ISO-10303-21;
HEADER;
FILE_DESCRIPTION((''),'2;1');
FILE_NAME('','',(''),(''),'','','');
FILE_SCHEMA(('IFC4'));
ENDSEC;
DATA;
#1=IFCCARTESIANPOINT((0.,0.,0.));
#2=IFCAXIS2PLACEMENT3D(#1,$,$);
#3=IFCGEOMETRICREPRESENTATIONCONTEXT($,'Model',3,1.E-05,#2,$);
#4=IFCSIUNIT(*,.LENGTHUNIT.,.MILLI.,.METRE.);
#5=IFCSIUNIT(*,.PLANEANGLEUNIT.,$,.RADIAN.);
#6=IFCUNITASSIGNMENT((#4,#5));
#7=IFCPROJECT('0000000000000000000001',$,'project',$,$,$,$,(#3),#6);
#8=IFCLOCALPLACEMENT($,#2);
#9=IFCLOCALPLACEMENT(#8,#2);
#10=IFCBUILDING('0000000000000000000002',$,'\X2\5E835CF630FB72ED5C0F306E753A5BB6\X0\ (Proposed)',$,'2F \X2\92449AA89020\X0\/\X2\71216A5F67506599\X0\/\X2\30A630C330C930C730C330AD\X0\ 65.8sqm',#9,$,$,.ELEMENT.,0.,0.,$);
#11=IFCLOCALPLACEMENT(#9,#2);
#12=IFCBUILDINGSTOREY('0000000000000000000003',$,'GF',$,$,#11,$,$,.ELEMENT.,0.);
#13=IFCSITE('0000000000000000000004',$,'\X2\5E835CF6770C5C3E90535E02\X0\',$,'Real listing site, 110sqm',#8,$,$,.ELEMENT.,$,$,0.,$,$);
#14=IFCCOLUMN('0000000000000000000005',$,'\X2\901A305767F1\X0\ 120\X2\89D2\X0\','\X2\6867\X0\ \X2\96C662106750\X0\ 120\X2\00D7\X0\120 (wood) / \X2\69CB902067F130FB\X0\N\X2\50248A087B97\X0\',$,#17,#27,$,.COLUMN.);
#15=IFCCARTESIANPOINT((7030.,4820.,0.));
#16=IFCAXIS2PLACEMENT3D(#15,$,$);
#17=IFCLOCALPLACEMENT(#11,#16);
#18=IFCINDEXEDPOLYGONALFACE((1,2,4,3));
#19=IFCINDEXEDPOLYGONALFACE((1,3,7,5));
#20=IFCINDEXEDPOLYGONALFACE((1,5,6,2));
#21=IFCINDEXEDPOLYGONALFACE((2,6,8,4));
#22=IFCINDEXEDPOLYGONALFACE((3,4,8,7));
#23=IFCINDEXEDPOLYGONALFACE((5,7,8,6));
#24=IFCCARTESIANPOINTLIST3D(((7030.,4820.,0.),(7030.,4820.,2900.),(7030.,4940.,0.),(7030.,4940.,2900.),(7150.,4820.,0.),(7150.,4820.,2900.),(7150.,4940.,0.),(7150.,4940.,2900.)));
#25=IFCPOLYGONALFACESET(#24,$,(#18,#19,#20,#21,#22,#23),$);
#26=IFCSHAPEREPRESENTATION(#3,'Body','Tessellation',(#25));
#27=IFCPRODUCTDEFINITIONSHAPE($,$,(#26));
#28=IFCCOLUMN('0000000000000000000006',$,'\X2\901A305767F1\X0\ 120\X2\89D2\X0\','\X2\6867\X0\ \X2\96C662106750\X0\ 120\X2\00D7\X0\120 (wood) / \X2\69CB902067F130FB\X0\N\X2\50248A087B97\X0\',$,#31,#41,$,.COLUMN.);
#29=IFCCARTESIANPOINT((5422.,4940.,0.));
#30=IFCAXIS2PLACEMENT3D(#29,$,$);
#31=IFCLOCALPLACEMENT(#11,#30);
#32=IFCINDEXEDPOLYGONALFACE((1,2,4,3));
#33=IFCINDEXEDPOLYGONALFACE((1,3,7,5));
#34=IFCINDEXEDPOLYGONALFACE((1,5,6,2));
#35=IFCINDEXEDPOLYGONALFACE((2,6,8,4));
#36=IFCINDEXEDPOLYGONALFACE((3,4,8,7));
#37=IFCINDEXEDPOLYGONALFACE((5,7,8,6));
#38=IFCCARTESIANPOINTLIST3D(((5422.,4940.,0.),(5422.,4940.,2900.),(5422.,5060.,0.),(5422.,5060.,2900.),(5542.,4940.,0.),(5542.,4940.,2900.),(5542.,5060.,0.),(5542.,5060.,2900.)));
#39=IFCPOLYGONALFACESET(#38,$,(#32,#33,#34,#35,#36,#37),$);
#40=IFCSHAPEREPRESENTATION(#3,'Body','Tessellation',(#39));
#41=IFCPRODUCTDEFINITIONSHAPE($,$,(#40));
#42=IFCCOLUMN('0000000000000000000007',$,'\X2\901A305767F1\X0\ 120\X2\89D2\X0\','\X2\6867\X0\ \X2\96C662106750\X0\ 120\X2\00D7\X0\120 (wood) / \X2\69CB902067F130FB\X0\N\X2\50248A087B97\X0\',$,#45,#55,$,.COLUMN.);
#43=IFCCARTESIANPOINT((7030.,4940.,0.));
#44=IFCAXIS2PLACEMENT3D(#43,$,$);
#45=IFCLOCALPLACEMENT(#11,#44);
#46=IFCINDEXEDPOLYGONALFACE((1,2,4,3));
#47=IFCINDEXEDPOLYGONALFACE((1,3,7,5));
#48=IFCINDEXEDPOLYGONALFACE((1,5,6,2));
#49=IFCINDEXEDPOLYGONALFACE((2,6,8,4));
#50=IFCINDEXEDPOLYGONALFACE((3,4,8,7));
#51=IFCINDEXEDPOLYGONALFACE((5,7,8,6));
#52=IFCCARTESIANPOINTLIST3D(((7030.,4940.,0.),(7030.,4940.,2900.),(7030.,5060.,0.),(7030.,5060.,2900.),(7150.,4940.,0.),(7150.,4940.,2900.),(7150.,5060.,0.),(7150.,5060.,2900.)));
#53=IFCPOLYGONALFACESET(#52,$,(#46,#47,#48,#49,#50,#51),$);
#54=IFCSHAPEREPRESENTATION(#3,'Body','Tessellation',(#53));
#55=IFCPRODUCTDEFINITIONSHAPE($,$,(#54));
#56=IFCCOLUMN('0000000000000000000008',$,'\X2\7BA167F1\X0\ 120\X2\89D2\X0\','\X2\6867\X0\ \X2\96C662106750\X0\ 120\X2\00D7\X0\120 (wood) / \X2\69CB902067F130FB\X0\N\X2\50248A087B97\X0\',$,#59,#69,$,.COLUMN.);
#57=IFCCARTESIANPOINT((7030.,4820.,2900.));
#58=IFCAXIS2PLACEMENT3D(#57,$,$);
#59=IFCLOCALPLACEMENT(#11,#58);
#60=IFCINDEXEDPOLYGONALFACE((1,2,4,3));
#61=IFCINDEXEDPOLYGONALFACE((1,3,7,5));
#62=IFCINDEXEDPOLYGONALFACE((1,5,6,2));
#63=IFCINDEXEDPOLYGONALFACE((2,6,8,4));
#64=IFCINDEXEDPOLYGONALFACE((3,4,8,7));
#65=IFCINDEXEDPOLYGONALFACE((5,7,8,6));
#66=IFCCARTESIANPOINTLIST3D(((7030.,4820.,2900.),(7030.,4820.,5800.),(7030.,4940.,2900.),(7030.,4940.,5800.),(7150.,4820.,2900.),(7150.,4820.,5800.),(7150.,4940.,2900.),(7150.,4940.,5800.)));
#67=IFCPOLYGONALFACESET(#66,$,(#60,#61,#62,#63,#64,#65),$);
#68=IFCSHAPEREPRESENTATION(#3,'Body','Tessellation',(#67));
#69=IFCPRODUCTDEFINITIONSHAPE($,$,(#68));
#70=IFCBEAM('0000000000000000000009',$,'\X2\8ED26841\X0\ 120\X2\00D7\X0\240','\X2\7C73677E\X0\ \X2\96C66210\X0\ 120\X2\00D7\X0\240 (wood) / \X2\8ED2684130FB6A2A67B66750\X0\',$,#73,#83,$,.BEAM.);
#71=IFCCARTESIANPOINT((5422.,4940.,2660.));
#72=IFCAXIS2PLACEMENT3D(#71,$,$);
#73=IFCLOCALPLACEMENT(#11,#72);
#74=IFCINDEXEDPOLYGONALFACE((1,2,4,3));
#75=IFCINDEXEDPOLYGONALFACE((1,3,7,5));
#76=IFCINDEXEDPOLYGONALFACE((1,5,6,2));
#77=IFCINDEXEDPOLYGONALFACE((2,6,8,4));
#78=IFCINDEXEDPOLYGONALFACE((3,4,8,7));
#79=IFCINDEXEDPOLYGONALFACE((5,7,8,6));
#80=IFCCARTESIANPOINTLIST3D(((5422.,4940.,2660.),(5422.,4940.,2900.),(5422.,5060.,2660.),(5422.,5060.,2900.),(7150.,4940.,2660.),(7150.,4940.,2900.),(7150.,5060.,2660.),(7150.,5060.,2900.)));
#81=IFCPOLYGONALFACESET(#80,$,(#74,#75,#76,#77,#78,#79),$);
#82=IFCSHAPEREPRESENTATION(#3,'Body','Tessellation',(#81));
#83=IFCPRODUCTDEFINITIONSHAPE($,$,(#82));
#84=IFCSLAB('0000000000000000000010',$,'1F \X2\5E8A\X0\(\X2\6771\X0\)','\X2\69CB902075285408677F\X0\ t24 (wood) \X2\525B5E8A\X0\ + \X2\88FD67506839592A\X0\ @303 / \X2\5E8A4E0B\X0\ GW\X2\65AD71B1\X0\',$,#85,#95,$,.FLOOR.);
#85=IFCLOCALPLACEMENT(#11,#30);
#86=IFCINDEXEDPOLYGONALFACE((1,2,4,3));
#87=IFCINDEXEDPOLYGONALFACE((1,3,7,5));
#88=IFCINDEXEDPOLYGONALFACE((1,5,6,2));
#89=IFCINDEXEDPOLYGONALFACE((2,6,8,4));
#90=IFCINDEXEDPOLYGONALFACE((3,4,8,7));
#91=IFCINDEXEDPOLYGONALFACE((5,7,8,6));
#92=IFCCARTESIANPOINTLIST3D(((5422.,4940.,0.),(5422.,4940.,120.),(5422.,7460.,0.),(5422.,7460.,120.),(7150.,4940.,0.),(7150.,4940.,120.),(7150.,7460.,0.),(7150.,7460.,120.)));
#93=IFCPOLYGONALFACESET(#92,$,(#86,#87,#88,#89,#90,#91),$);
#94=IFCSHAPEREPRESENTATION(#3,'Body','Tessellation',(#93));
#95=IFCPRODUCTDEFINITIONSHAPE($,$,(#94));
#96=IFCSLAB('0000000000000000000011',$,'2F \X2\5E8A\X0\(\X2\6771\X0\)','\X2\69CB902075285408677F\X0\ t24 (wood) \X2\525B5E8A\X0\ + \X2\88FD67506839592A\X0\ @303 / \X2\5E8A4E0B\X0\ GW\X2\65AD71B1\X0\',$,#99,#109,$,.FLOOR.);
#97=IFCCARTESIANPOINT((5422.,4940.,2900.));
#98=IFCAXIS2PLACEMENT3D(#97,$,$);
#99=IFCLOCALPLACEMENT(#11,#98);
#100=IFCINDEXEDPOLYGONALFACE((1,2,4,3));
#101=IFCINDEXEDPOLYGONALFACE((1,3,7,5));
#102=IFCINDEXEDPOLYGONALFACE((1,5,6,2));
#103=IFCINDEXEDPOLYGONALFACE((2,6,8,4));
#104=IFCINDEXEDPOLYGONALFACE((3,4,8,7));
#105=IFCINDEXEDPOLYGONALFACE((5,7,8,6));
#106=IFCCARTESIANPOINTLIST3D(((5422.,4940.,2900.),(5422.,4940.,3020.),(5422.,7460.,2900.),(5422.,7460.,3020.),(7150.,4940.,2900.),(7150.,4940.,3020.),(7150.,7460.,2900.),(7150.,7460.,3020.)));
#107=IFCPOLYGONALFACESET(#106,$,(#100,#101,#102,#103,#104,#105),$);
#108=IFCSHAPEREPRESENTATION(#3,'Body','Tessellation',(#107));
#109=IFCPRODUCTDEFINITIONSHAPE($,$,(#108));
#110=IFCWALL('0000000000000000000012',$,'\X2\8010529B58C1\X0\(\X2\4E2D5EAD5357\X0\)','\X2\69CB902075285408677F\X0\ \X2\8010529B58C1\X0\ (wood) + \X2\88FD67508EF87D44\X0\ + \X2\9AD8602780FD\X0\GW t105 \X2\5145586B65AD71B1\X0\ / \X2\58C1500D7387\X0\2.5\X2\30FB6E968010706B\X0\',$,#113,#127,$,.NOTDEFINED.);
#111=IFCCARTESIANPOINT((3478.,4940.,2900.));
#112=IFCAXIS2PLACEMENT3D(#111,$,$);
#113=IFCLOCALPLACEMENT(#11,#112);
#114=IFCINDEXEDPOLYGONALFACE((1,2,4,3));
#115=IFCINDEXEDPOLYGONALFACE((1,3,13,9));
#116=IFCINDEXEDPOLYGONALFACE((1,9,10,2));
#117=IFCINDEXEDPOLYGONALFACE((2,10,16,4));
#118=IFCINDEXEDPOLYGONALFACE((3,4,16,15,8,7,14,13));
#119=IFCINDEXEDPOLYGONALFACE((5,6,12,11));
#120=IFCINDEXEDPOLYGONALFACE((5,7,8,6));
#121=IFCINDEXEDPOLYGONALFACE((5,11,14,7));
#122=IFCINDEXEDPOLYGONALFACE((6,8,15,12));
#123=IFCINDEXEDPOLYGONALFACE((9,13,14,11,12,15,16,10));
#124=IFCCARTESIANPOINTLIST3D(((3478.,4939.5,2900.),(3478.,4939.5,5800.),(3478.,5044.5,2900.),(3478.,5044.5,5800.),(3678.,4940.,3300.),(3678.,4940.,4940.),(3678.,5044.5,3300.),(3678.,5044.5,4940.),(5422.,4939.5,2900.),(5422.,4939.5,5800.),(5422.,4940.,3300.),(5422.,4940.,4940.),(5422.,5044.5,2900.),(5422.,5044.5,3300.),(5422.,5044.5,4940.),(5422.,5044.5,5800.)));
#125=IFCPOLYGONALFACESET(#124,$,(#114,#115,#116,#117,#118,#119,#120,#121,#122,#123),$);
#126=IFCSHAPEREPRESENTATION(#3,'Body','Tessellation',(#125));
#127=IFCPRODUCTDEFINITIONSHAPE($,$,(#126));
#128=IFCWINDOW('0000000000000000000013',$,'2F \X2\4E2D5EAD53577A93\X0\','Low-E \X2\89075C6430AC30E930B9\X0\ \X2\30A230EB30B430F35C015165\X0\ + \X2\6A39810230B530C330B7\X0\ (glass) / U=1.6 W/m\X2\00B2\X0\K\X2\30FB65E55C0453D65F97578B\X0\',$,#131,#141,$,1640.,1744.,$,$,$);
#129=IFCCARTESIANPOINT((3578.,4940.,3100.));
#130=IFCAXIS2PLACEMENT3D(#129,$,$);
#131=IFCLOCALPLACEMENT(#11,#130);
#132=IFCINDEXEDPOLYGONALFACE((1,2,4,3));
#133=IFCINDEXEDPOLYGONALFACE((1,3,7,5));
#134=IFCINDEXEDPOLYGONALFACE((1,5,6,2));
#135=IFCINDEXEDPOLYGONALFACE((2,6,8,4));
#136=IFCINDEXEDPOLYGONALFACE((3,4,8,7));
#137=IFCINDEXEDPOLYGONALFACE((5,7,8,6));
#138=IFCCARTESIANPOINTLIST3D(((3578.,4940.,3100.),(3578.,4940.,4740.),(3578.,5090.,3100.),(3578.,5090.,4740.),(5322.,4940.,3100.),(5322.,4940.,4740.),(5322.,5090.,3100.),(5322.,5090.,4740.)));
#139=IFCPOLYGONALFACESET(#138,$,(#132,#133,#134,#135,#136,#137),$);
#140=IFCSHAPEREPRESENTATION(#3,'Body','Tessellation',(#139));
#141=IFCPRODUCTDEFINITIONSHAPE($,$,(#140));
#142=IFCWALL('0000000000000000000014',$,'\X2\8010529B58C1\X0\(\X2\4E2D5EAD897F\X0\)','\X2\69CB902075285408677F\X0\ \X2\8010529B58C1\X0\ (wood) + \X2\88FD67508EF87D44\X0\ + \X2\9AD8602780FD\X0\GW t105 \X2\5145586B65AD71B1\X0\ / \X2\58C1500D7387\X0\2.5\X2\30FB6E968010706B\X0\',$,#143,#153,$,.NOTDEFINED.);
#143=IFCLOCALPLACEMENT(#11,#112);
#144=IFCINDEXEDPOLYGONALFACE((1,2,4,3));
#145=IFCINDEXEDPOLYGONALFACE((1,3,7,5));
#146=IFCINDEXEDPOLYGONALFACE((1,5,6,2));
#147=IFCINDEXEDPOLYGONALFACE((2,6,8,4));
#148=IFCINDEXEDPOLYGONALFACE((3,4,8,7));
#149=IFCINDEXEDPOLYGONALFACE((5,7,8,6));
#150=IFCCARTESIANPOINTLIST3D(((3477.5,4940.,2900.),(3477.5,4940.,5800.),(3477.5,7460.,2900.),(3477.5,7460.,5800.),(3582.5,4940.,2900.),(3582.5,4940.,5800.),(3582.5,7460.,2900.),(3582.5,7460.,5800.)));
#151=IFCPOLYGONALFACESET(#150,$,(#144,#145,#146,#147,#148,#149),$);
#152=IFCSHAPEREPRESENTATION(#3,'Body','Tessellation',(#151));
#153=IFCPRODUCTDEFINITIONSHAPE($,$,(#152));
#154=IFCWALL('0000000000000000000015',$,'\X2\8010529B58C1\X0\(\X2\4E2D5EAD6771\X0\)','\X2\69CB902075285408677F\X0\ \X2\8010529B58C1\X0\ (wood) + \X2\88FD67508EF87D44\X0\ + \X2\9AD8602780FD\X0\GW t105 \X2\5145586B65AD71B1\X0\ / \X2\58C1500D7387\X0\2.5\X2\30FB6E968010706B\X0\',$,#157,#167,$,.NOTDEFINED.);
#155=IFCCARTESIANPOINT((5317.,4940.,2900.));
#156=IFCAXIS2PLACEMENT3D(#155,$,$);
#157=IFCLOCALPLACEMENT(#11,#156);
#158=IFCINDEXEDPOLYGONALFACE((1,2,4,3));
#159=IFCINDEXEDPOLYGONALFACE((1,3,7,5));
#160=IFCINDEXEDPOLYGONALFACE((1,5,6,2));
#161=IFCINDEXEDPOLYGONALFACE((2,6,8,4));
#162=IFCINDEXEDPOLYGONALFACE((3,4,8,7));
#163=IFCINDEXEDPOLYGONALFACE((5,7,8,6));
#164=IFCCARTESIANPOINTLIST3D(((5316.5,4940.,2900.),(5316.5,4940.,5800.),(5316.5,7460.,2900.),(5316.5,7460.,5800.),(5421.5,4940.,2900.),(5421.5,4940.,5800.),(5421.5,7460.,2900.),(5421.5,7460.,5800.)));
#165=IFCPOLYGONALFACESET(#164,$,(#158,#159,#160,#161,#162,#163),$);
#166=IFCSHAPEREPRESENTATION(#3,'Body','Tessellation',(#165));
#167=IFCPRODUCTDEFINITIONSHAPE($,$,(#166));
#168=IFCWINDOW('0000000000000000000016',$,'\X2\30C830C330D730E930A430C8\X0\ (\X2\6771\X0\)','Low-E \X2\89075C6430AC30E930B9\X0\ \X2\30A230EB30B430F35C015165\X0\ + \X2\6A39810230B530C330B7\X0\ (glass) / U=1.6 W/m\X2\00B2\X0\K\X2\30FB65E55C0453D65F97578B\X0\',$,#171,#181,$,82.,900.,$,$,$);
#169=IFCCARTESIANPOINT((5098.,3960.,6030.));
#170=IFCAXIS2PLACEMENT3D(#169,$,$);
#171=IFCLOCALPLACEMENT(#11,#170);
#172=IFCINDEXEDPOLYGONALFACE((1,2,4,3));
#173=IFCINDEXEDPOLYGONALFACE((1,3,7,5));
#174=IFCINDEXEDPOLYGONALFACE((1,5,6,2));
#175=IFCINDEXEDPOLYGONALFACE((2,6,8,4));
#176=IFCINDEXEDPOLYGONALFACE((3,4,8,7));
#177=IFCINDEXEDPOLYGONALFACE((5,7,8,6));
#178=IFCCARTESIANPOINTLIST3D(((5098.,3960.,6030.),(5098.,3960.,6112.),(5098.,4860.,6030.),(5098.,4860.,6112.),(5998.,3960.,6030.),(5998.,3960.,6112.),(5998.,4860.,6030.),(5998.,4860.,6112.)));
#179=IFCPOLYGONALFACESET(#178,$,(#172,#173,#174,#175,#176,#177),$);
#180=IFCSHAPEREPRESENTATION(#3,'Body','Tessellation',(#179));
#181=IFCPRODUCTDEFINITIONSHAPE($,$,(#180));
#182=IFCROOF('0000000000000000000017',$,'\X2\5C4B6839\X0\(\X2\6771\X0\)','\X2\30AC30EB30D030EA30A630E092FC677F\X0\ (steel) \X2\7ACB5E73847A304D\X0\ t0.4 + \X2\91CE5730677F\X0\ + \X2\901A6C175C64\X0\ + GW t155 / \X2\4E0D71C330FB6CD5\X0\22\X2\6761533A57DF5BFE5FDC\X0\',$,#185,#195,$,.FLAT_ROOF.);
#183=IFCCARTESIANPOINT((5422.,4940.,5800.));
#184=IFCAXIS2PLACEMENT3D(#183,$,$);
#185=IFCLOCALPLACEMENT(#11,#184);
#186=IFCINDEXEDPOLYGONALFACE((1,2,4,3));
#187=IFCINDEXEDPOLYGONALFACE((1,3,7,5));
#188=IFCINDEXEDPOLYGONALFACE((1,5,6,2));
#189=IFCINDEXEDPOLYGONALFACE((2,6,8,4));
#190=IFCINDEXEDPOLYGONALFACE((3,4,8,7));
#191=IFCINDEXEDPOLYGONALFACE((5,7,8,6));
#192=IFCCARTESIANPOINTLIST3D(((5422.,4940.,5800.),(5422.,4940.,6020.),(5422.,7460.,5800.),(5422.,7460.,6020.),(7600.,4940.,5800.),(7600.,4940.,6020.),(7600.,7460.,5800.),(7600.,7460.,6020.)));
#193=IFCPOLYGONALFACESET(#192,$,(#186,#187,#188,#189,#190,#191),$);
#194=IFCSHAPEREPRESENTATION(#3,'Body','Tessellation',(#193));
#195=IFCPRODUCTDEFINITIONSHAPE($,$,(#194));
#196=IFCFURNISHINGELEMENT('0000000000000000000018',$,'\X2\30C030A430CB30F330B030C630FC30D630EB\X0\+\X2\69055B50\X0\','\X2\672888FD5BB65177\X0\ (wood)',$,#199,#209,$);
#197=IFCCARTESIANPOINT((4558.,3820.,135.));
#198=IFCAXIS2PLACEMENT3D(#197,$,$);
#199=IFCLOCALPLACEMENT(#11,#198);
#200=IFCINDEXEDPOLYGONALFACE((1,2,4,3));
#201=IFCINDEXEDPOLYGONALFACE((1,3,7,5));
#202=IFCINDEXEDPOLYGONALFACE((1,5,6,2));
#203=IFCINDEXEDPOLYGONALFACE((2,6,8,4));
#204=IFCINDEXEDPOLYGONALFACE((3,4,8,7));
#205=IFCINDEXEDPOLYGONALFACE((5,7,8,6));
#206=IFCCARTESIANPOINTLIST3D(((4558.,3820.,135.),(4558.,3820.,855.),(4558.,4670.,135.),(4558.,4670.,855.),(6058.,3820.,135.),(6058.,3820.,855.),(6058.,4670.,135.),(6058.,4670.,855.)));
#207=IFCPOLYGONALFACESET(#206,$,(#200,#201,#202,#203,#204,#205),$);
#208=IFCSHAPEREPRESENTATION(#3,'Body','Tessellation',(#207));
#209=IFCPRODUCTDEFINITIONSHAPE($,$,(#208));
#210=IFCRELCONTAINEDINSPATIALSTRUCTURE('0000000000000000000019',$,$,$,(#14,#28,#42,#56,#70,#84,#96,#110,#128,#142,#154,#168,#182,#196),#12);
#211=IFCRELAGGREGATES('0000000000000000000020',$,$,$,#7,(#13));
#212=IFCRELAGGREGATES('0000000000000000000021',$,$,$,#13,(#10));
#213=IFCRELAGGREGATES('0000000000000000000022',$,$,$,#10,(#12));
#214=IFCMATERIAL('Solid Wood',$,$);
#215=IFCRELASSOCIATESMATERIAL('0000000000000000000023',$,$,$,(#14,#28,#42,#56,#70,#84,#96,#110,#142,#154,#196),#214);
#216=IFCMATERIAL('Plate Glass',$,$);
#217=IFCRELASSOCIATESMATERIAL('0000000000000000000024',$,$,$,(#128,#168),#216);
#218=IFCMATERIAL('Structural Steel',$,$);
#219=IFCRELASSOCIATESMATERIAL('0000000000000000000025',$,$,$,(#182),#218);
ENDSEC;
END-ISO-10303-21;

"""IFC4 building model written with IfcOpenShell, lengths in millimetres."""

from ifc_helpers import new_model, si_unit, frame, frame_2d, origin, place, context, project, spatial, rectangle, extrude, material, element, fill, save


model = new_model("IFC4")

# Units and contexts
model_context = context("Model", 3, precision=1e-05, world=origin())
ifc_project = project(units=[si_unit("LENGTHUNIT", "METRE", prefix="MILLI"), si_unit("PLANEANGLEUNIT", "RADIAN")], contexts=[model_context])

# Site, building, storey
site_placement = place(None, origin())
site = spatial("IfcSite", under=ifc_project, at=site_placement, Name="広島県尾道市", ObjectType="Real listing site, 110sqm", CompositionType="ELEMENT", RefElevation=0.0)
building_placement = place(site_placement, origin())
building = spatial("IfcBuilding", under=site, at=building_placement, Name="広島・狭小の町家 (Proposed)", ObjectType="2F 鉄骨造/無機材料/ウッドデッキ 65.8sqm", CompositionType="ELEMENT", ElevationOfRefHeight=0.0, ElevationOfTerrain=0.0)
storey_placement = place(building_placement, origin())
storey = spatial("IfcBuildingStorey", under=building, at=storey_placement, Name="GF", CompositionType="ELEMENT", Elevation=0.0)

# Columns
ifc_material_1 = material(Name="Solid Wood")
column_1_placement = place(storey_placement, frame((7030.0, 4820.0, 0.0)))
element("IfcColumn", 1, at=column_1_placement, inside=storey, material=ifc_material_1, Name="通し柱 120角", Description="桧 集成材 120×120 (wood) / 構造柱・N値計算", PredefinedType="COLUMN", context=model_context, shape_type="SweptSolid", body=[
    extrude(rectangle(XDim=120.0, YDim=120.0, at=frame_2d((60.0, 60.0))), frame((7030.0, 4820.0, 0.0)), (0.0, 0.0, 1.0), 2900.0),
])
column_2_placement = place(storey_placement, frame((5422.0, 4940.0, 0.0)))
element("IfcColumn", 2, at=column_2_placement, inside=storey, material=ifc_material_1, Name="通し柱 120角", Description="桧 集成材 120×120 (wood) / 構造柱・N値計算", PredefinedType="COLUMN", context=model_context, shape_type="SweptSolid", body=[
    extrude(rectangle(XDim=120.0, YDim=120.0, at=frame_2d((60.0, 60.0))), frame((5422.0, 4940.0, 0.0)), (0.0, 0.0, 1.0), 2900.0),
])
column_3_placement = place(storey_placement, frame((7030.0, 4940.0, 0.0)))
element("IfcColumn", 3, at=column_3_placement, inside=storey, material=ifc_material_1, Name="通し柱 120角", Description="桧 集成材 120×120 (wood) / 構造柱・N値計算", PredefinedType="COLUMN", context=model_context, shape_type="SweptSolid", body=[
    extrude(rectangle(XDim=120.0, YDim=120.0, at=frame_2d((60.0, 60.0))), frame((7030.0, 4940.0, 0.0)), (0.0, 0.0, 1.0), 2900.0),
])
column_4_placement = place(storey_placement, frame((7030.0, 4820.0, 2900.0)))
element("IfcColumn", 4, at=column_4_placement, inside=storey, material=ifc_material_1, Name="管柱 120角", Description="桧 集成材 120×120 (wood) / 構造柱・N値計算", PredefinedType="COLUMN", context=model_context, shape_type="SweptSolid", body=[
    extrude(rectangle(XDim=120.0, YDim=120.0, at=frame_2d((60.0, 60.0))), frame((7030.0, 4820.0, 2900.0)), (0.0, 0.0, 1.0), 2900.0),
])

# Beam
beam_1_placement = place(storey_placement, frame((5422.0, 4940.0, 2660.0)))
element("IfcBeam", 5, at=beam_1_placement, inside=storey, material=ifc_material_1, Name="軒桁 120×240", Description="米松 集成 120×240 (wood) / 軒桁・横架材", PredefinedType="BEAM", context=model_context, shape_type="SweptSolid", body=[
    extrude(rectangle(XDim=1728.0, YDim=120.0, at=frame_2d((864.0, 60.0))), frame((5422.0, 4940.0, 2660.0)), (0.0, 0.0, 1.0), 240.0),
])

# Slabs
slab_1_placement = place(storey_placement, frame((5422.0, 4940.0, 0.0)))
element("IfcSlab", 6, at=slab_1_placement, inside=storey, material=ifc_material_1, Name="1F 床(東)", Description="構造用合板 t24 (wood) 剛床 + 製材根太 @303 / 床下 GW断熱", PredefinedType="FLOOR", context=model_context, shape_type="SweptSolid", body=[
    extrude(rectangle(XDim=1728.0, YDim=2520.0, at=frame_2d((864.0, 1260.0))), frame((5422.0, 4940.0, 0.0)), (0.0, 0.0, 1.0), 120.0),
])
slab_2_placement = place(storey_placement, frame((5422.0, 4940.0, 2900.0)))
element("IfcSlab", 7, at=slab_2_placement, inside=storey, material=ifc_material_1, Name="2F 床(東)", Description="構造用合板 t24 (wood) 剛床 + 製材根太 @303 / 床下 GW断熱", PredefinedType="FLOOR", context=model_context, shape_type="SweptSolid", body=[
    extrude(rectangle(XDim=1728.0, YDim=2520.0, at=frame_2d((864.0, 1260.0))), frame((5422.0, 4940.0, 2900.0)), (0.0, 0.0, 1.0), 120.0),
])

# Wall, opening, window
wall_1_placement = place(storey_placement, frame((3478.0, 4940.0, 2900.0)))
wall_1 = element("IfcWall", 8, at=wall_1_placement, inside=storey, material=ifc_material_1, Name="耐力壁(中庭南)", Description="構造用合板 耐力壁 (wood) + 製材軸組 + 高性能GW t105 充填断熱 / 壁倍率2.5・準耐火", PredefinedType="NOTDEFINED", context=model_context, shape_type="SweptSolid", body=[
    extrude(rectangle(XDim=1944.0, YDim=105.0, at=frame_2d((972.0, 52.0))), frame((3478.0, 4940.0, 2900.0)), (0.0, 0.0, 1.0), 2900.0),
])
opening_placement = place(storey_placement, frame((3578.0, 4940.0, 3100.0)))
opening = element("IfcOpeningElement", 9, at=opening_placement, cuts=wall_1, PredefinedType="NOTDEFINED", context=model_context, shape_type="SweptSolid", body=[
    extrude(rectangle(XDim=1744.0, YDim=150.0, at=frame_2d((872.0, 75.0))), frame((3578.0, 4940.0, 3100.0)), (0.0, 0.0, 1.0), 1640.0),
])
ifc_material_2 = material(Name="Plate Glass")
window_1_placement = place(storey_placement, frame((3578.0, 4940.0, 3100.0)))
window_1 = element("IfcWindow", 10, at=window_1_placement, inside=storey, material=ifc_material_2, Name="2F 中庭南窓", Description="Low-E 複層ガラス アルゴン封入 + 樹脂サッシ (glass) / U=1.6 W/m²K・日射取得型", OverallHeight=1640.0, OverallWidth=1744.0, context=model_context, shape_type="SweptSolid", body=[
    extrude(rectangle(XDim=1744.0, YDim=150.0, at=frame_2d((872.0, 75.0))), frame((3578.0, 4940.0, 3100.0)), (0.0, 0.0, 1.0), 1640.0),
])
fill(opening, window_1)

# Walls
wall_2_placement = place(storey_placement, frame((3478.0, 4940.0, 2900.0)))
element("IfcWall", 11, at=wall_2_placement, inside=storey, material=ifc_material_1, Name="耐力壁(中庭西)", Description="構造用合板 耐力壁 (wood) + 製材軸組 + 高性能GW t105 充填断熱 / 壁倍率2.5・準耐火", PredefinedType="NOTDEFINED", context=model_context, shape_type="SweptSolid", body=[
    extrude(rectangle(XDim=105.0, YDim=2520.0, at=frame_2d((52.0, 1260.0))), frame((3478.0, 4940.0, 2900.0)), (0.0, 0.0, 1.0), 2900.0),
])
wall_3_placement = place(storey_placement, frame((5317.0, 4940.0, 2900.0)))
element("IfcWall", 12, at=wall_3_placement, inside=storey, material=ifc_material_1, Name="耐力壁(中庭東)", Description="構造用合板 耐力壁 (wood) + 製材軸組 + 高性能GW t105 充填断熱 / 壁倍率2.5・準耐火", PredefinedType="NOTDEFINED", context=model_context, shape_type="SweptSolid", body=[
    extrude(rectangle(XDim=105.0, YDim=2520.0, at=frame_2d((52.0, 1260.0))), frame((5317.0, 4940.0, 2900.0)), (0.0, 0.0, 1.0), 2900.0),
])

# Window
window_2_placement = place(storey_placement, frame((5098.0, 3960.0, 6030.0)))
element("IfcWindow", 13, at=window_2_placement, inside=storey, material=ifc_material_2, Name="トップライト (東)", Description="Low-E 複層ガラス アルゴン封入 + 樹脂サッシ (glass) / U=1.6 W/m²K・日射取得型", OverallHeight=82.0, OverallWidth=900.0, context=model_context, shape_type="SweptSolid", body=[
    extrude(rectangle(XDim=900.0, YDim=900.0, at=frame_2d((450.0, 450.0))), frame((5098.0, 3960.0, 6030.0)), (0.0, 0.0, 1.0), 82.0),
])

# Roof
ifc_material_3 = material(Name="Structural Steel")
for number, where, name in (
    (14, (5422.0, 4940.0, 5800.0), "屋根(東)"),
):
    element("IfcRoof", number, at=place(storey_placement, frame(where)), inside=storey, material=ifc_material_3, Name=name, Description="ガルバリウム鋼板 (steel) 立平葺き t0.4 + 野地板 + 通気層 + GW t155 / 不燃・法22条区域対応", PredefinedType="FLAT_ROOF", context=model_context, shape_type="SweptSolid", body=[
        extrude(rectangle(XDim=2178.0, YDim=2520.0, at=frame_2d((1089.0, 1260.0))), frame((5422.0, 4940.0, 5800.0)), (0.0, 0.0, 1.0), 220.0),
    ])

# Furnishing element
furnishing_1_placement = place(storey_placement, frame((4558.0, 3820.0, 135.0)))
element("IfcFurnishingElement", 15, at=furnishing_1_placement, inside=storey, material=ifc_material_1, Name="ダイニングテーブル+椅子", Description="木製家具 (wood)", context=model_context, shape_type="SweptSolid", body=[
    extrude(rectangle(XDim=1500.0, YDim=850.0, at=frame_2d((750.0, 425.0))), frame((4558.0, 3820.0, 135.0)), (0.0, 0.0, 1.0), 720.0),
])

save(model, "model.ifc")
